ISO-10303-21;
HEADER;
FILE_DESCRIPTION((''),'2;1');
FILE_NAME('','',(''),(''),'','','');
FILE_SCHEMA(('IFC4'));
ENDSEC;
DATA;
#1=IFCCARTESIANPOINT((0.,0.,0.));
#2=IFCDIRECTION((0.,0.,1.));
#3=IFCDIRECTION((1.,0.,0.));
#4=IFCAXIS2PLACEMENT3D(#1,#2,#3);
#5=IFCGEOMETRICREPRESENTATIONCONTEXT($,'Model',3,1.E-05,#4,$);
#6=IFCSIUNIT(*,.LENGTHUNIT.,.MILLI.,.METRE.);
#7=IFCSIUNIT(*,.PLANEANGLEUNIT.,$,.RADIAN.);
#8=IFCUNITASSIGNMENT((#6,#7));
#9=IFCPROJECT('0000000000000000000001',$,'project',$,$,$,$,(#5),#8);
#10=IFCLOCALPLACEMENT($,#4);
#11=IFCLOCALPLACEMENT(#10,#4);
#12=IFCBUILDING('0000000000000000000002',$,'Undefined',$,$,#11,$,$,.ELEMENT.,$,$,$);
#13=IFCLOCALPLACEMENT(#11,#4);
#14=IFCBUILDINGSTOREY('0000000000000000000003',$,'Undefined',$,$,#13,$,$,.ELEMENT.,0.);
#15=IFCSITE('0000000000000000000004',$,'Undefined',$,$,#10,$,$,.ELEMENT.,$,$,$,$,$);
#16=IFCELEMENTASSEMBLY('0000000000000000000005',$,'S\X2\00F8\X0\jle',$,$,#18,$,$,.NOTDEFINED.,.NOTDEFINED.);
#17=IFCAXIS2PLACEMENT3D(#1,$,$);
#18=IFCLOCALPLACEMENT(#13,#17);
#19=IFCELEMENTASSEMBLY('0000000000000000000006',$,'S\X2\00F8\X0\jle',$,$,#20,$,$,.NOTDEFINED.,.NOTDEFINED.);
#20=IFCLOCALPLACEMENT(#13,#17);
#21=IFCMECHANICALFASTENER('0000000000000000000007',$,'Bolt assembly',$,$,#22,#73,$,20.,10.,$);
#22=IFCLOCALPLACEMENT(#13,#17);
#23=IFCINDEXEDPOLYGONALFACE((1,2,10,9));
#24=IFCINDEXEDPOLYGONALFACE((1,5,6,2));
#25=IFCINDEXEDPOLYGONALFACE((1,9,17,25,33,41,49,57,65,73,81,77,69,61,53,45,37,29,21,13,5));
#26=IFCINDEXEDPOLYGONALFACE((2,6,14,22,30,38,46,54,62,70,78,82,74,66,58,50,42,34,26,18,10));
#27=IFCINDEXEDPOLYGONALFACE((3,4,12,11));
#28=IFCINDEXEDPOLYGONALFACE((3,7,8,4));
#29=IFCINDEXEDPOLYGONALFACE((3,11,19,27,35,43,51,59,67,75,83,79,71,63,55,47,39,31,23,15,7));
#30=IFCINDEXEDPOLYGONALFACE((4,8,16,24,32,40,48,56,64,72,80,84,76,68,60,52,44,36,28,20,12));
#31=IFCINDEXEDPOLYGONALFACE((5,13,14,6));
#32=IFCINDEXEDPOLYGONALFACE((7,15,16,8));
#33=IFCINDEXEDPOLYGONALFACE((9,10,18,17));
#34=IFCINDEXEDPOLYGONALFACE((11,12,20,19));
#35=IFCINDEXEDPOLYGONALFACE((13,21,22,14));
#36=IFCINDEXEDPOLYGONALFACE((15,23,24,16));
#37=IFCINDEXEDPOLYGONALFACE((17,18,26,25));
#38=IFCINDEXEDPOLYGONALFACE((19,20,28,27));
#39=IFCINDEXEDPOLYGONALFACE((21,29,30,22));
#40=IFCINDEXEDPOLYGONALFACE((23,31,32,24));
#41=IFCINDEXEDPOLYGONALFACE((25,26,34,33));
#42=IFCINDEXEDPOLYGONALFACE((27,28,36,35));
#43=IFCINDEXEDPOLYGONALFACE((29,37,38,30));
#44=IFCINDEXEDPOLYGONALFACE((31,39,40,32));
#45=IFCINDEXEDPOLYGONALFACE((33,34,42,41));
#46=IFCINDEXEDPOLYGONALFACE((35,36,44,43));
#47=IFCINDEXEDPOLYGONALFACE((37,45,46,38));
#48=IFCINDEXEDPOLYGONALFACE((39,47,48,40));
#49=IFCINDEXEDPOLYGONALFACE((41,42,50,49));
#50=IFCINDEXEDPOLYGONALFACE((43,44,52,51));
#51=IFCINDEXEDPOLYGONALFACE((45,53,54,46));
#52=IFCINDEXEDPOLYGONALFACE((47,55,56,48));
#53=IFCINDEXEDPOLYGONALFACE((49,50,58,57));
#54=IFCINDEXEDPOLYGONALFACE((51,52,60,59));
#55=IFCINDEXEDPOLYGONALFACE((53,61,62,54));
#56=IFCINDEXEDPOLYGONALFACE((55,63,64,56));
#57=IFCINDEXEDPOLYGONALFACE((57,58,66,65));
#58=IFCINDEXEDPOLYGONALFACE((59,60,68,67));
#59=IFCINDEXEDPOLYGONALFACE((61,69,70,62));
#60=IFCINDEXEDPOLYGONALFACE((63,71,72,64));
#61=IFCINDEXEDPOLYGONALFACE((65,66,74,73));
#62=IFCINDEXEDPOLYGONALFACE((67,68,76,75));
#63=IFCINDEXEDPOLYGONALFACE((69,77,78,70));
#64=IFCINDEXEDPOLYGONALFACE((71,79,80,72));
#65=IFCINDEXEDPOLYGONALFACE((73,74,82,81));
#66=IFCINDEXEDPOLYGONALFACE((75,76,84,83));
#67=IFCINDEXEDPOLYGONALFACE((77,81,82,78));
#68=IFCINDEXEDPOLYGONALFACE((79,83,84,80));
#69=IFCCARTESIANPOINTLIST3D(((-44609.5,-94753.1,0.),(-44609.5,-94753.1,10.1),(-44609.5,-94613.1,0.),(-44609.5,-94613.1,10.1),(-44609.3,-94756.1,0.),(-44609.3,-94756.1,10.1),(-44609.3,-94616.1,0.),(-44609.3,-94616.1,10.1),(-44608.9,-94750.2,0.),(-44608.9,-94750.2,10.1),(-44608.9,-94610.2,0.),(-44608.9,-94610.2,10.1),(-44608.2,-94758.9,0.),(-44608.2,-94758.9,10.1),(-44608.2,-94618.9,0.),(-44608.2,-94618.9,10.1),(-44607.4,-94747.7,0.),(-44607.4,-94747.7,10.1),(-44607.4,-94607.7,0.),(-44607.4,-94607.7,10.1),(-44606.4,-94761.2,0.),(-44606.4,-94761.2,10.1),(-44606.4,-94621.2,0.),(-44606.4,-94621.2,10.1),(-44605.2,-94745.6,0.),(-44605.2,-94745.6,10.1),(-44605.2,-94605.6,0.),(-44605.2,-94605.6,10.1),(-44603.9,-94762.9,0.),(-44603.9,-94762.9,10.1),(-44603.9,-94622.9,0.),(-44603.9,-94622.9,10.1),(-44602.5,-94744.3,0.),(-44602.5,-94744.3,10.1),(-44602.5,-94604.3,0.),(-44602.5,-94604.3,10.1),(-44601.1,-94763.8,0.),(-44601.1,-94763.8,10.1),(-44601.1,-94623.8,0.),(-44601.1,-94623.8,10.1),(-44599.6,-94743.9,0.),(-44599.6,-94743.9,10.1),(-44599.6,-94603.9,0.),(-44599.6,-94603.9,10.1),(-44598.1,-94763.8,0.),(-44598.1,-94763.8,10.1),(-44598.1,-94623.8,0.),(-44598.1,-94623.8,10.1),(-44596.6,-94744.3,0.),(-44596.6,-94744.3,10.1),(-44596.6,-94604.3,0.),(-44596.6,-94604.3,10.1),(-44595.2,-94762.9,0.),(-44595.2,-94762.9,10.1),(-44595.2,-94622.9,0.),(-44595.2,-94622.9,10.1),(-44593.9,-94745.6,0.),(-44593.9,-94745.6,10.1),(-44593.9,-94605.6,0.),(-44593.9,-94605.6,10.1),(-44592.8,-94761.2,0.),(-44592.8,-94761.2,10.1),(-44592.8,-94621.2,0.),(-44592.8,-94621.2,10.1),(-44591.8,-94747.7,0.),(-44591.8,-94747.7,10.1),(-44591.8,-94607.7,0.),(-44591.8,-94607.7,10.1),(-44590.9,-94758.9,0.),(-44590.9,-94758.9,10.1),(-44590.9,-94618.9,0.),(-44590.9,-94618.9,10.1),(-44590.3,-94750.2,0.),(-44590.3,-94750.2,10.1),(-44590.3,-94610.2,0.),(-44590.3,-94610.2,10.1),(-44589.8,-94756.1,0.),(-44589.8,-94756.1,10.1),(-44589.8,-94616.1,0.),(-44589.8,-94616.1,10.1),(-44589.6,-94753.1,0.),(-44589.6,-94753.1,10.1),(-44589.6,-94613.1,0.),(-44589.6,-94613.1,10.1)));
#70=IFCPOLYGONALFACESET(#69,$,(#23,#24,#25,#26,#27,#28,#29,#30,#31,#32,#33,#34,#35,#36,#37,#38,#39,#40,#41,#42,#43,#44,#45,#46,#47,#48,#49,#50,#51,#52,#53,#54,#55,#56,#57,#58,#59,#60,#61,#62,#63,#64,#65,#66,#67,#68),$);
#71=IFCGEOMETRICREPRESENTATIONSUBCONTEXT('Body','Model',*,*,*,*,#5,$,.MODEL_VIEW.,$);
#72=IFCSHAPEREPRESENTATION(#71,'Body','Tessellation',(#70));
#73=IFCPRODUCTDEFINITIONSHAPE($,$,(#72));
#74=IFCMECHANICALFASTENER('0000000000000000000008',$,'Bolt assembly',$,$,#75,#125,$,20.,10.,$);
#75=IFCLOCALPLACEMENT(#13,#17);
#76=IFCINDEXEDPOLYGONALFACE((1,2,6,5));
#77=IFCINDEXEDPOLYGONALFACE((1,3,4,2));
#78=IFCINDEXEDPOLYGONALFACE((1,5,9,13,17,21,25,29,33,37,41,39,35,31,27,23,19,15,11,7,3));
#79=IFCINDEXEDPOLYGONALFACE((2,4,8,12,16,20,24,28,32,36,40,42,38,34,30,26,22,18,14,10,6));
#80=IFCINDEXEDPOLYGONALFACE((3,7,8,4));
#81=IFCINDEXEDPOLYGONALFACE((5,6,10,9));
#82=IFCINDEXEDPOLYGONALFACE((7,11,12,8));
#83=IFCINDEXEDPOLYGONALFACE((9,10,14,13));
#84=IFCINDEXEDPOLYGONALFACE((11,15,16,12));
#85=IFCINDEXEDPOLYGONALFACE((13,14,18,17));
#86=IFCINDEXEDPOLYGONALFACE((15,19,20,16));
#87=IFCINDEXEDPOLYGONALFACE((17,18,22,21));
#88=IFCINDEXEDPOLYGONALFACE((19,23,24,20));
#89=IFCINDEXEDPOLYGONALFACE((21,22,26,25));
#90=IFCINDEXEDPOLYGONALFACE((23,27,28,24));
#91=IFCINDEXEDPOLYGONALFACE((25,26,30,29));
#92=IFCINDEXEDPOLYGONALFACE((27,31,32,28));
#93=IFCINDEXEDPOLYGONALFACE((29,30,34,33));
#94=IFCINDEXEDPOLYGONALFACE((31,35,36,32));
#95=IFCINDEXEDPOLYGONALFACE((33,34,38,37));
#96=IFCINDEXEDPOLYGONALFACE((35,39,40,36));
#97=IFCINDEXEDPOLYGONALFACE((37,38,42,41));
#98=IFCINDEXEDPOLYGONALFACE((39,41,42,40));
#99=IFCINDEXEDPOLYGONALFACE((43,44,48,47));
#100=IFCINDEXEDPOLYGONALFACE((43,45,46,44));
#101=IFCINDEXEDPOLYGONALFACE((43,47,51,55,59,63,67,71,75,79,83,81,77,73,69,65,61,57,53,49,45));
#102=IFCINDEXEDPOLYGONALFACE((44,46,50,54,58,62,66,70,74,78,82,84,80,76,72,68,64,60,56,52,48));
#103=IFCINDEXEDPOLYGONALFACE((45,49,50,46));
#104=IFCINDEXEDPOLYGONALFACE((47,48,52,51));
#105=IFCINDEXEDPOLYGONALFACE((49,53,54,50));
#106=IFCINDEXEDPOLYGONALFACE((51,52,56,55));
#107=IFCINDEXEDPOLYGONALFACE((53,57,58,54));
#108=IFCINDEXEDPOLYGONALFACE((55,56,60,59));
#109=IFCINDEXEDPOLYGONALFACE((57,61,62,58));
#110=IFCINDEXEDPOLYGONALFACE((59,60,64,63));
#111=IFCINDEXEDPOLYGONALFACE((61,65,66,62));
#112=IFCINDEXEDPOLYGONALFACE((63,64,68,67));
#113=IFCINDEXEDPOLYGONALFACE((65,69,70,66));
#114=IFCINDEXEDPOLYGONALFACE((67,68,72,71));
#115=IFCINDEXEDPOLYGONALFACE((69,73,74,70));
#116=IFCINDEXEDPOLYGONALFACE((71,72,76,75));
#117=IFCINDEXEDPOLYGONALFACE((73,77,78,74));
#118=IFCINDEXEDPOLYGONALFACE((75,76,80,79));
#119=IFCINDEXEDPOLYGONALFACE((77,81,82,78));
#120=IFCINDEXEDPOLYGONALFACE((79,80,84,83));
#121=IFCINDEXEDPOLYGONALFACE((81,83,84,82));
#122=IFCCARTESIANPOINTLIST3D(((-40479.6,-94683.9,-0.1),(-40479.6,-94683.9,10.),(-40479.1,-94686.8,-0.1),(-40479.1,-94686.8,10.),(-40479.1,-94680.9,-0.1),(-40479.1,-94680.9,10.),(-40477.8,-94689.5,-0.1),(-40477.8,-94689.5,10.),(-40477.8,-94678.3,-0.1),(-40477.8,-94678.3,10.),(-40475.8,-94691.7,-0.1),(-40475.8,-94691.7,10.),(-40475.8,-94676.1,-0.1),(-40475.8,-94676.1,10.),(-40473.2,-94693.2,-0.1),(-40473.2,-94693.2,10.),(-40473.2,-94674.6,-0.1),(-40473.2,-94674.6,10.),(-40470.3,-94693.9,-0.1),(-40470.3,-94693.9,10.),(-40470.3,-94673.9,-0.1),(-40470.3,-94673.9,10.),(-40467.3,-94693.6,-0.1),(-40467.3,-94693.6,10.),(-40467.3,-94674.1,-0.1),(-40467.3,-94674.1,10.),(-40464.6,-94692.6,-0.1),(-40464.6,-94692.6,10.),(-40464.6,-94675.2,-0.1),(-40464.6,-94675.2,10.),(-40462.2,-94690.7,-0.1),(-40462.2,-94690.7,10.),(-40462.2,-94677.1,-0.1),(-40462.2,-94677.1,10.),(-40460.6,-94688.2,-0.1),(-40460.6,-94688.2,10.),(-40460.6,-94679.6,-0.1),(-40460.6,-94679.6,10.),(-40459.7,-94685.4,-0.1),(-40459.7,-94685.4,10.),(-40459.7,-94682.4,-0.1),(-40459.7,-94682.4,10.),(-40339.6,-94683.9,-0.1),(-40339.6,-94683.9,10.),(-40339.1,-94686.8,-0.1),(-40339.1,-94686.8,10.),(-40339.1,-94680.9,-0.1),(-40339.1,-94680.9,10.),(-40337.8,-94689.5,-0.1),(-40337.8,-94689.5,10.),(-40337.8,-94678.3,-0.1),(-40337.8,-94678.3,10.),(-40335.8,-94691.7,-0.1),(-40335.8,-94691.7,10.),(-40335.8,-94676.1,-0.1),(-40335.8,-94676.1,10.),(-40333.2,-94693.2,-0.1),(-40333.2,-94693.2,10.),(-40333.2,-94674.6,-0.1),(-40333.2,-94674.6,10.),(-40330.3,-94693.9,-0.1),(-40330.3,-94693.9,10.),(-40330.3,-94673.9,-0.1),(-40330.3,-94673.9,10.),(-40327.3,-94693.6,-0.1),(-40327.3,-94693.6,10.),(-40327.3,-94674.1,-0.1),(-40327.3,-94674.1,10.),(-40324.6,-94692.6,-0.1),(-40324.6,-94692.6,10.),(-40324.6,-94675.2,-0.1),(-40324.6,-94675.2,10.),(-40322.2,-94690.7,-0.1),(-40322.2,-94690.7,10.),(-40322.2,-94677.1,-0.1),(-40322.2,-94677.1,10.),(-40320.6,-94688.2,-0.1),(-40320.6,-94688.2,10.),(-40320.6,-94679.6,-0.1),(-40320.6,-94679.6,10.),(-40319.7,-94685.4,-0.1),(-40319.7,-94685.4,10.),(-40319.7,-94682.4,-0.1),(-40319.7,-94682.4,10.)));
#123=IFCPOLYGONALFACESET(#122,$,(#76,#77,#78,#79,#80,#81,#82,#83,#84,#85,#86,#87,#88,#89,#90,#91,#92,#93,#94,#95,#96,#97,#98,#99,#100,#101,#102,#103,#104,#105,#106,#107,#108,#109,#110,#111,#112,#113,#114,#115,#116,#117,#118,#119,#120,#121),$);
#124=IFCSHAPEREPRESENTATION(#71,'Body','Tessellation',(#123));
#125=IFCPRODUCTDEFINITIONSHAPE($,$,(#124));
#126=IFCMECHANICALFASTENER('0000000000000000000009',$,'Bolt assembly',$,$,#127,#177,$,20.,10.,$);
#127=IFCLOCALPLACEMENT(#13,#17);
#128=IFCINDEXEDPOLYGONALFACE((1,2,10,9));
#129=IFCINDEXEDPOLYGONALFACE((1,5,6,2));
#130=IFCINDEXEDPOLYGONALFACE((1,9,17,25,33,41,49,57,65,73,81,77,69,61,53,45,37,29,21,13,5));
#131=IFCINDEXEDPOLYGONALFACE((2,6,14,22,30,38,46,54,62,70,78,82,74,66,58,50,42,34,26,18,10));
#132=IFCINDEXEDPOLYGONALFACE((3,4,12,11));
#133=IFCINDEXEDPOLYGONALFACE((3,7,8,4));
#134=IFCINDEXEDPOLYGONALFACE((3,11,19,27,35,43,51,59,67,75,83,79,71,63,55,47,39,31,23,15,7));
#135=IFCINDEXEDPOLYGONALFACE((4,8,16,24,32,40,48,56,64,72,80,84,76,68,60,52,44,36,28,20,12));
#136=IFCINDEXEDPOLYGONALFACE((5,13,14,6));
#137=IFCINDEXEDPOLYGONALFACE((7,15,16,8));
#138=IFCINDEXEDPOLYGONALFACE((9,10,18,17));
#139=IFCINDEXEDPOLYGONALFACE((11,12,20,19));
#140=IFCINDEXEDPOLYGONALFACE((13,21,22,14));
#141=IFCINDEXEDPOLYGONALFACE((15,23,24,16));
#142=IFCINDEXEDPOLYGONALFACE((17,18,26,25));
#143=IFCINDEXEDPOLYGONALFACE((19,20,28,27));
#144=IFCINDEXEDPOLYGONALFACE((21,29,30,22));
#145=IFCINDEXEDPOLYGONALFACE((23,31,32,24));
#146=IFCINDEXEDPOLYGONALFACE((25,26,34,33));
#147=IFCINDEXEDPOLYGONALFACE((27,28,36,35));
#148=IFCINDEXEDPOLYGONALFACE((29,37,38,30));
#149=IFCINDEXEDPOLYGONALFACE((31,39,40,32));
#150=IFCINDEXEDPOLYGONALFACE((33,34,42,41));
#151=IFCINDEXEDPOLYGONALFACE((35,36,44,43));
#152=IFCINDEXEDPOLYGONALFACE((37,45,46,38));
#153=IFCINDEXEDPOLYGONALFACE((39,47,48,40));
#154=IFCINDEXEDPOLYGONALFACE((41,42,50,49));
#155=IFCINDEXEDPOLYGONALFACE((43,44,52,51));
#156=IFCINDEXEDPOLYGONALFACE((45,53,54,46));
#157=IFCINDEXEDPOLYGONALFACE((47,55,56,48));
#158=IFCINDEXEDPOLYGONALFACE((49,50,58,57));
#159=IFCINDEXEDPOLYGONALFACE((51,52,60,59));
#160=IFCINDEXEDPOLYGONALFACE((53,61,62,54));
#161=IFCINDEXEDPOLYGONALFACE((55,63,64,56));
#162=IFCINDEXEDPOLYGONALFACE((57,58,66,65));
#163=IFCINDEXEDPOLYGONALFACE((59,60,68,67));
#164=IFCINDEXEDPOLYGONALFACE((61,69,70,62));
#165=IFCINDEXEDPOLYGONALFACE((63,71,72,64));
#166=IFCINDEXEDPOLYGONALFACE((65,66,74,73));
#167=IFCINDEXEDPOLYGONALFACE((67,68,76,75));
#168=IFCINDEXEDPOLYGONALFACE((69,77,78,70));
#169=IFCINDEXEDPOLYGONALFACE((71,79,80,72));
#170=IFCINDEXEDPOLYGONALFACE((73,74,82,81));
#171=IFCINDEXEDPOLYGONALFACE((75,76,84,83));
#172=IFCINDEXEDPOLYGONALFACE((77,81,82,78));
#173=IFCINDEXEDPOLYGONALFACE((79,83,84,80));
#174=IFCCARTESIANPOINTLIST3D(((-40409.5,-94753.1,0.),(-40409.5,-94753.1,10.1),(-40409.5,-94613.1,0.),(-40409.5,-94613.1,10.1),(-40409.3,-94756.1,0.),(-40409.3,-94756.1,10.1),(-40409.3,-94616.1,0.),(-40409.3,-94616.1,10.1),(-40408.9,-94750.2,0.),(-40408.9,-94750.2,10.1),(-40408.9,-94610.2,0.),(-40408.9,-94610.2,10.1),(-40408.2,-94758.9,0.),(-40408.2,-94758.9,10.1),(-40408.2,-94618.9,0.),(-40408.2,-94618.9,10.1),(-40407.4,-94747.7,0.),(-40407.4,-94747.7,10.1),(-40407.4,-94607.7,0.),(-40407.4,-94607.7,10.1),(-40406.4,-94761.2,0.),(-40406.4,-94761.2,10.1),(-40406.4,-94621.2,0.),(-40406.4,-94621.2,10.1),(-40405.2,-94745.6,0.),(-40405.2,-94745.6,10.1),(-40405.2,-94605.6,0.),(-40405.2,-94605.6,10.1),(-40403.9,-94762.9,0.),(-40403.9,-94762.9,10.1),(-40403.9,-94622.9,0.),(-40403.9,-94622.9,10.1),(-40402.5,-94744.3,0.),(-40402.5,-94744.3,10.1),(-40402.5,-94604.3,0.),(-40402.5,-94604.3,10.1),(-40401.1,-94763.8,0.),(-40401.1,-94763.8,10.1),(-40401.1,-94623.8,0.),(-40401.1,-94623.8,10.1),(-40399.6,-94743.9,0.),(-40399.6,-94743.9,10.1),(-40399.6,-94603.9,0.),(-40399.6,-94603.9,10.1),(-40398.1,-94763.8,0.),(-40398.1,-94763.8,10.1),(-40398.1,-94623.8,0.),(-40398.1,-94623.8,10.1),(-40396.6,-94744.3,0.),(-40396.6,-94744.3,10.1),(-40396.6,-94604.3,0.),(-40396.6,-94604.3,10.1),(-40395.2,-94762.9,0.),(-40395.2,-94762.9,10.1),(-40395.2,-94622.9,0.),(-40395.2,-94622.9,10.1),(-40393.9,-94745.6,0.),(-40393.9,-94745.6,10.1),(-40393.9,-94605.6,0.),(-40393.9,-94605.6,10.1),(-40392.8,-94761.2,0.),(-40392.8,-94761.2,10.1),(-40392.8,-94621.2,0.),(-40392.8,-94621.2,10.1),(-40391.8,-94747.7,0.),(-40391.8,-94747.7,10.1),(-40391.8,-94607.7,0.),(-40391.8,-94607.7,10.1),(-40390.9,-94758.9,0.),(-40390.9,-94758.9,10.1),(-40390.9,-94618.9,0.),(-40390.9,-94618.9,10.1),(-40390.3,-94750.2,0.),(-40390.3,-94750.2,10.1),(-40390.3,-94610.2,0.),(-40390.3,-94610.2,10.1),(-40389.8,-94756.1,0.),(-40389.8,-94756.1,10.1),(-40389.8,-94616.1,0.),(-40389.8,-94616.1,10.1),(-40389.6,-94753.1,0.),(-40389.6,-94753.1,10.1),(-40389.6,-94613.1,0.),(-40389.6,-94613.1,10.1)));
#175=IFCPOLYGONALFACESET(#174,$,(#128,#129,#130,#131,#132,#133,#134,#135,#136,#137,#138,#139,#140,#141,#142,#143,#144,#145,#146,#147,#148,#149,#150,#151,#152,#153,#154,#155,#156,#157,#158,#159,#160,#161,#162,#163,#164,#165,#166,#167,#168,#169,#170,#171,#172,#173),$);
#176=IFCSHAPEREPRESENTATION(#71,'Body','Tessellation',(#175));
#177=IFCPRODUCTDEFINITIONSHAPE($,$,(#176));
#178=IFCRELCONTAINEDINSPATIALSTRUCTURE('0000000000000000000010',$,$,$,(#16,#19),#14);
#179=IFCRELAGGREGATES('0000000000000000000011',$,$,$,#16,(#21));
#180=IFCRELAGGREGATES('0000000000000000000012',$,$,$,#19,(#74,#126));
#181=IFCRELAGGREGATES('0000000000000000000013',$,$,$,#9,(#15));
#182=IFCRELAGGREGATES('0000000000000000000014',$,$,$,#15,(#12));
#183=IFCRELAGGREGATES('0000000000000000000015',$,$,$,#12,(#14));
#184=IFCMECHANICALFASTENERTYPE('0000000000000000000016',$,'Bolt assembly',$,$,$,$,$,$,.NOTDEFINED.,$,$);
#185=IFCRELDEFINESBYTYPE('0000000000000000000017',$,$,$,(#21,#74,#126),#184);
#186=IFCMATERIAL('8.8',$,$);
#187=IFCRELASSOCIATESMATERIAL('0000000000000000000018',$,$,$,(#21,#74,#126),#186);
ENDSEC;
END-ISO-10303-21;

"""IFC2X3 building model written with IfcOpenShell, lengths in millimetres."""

from ifc_helpers import new_model, si_unit, frame, origin_with_axes, origin_2d_with_axis, place, context, subcontext, project, spatial, circle, extrude, source, transform, mapped, material, type_object, element, aggregate, save


model = new_model("IFC2X3")

# Units and contexts
model_context = context("Model", 3, precision=1e-05, world=origin_with_axes())
body_context = subcontext(model_context, "Body", "Model", "MODEL_VIEW")
ifc_project = project(units=[si_unit("LENGTHUNIT", "METRE", prefix="MILLI"), si_unit("PLANEANGLEUNIT", "RADIAN")], contexts=[model_context])

# Site, building, storey
site_placement = place(None, origin_with_axes())
site = spatial("IfcSite", under=ifc_project, at=site_placement, Name="Undefined", CompositionType="ELEMENT")
building_placement = place(site_placement, origin_with_axes())
building = spatial("IfcBuilding", under=site, at=building_placement, Name="Undefined", CompositionType="ELEMENT")
storey_placement = place(building_placement, origin_with_axes())
storey = spatial("IfcBuildingStorey", under=building, at=storey_placement, Name="Undefined", CompositionType="ELEMENT", Elevation=0.0)

# Element assemblies
assembly_1_placement = place(storey_placement, origin_with_axes())
assembly_1 = element("IfcElementAssembly", 1, at=assembly_1_placement, inside=storey, Name="Søjle", AssemblyPlace="NOTDEFINED", PredefinedType="NOTDEFINED")
assembly_2_placement = place(storey_placement, origin_with_axes())
assembly_2 = element("IfcElementAssembly", 2, at=assembly_2_placement, inside=storey, Name="Søjle", AssemblyPlace="NOTDEFINED", PredefinedType="NOTDEFINED")

# Mechanical fasteners
ifc_material_1 = material(Name="8.8")
mechanical_fastener_type = type_object("IfcMechanicalFastenerType", Name="Bolt assembly")
shared_shape_1 = source(origin_with_axes(), body_context, "Body", "SweptSolid", [
    extrude(circle(Radius=10.0, at=origin_2d_with_axis()), frame((0.0, -10.0, 0.0), z_axis=(0.0, 1.0, 0.0), x_axis=(1.0, 0.0, 0.0)), (0.0, 0.0, 1.0), 10.1),
])
mechanical_fastener_1_placement = place(assembly_1_placement, frame((-44599.6, -94753.9, 10.0), z_axis=(1.0, 0.0, 0.0), x_axis=(0.0, 1.0, 0.0)))
mechanical_fastener_1 = element("IfcMechanicalFastener", 3, at=mechanical_fastener_1_placement, type_object=mechanical_fastener_type, material=ifc_material_1, Name="Bolt assembly", NominalDiameter=20.0, NominalLength=10.0, context=body_context, shape_type="MappedRepresentation", body=[
    mapped(shared_shape_1, transform((0.0, 0.0, 0.0))),
    mapped(shared_shape_1, transform((140.0, 0.0, 0.0))),
])
mechanical_fastener_2_placement = place(assembly_2_placement, frame((-40329.6, -94683.9, 0.0), z_axis=(0.0, -1.0, 0.0), x_axis=(-1.0, 0.0, 0.0)))
mechanical_fastener_2 = element("IfcMechanicalFastener", 4, at=mechanical_fastener_2_placement, type_object=mechanical_fastener_type, material=ifc_material_1, Name="Bolt assembly", NominalDiameter=20.0, NominalLength=10.0, context=body_context, shape_type="MappedRepresentation", body=[
    mapped(shared_shape_1, transform((0.0, 0.0, 0.0))),
    mapped(shared_shape_1, transform((140.0, 0.0, 0.0))),
])
mechanical_fastener_3_placement = place(assembly_2_placement, frame((-40399.6, -94753.9, 10.0), z_axis=(1.0, 0.0, 0.0), x_axis=(0.0, 1.0, 0.0)))
mechanical_fastener_3 = element("IfcMechanicalFastener", 5, at=mechanical_fastener_3_placement, type_object=mechanical_fastener_type, material=ifc_material_1, Name="Bolt assembly", NominalDiameter=20.0, NominalLength=10.0, context=body_context, shape_type="MappedRepresentation", body=[
    mapped(shared_shape_1, transform((0.0, 0.0, 0.0))),
    mapped(shared_shape_1, transform((140.0, 0.0, 0.0))),
])
aggregate(assembly_1, [mechanical_fastener_1])
aggregate(assembly_2, [mechanical_fastener_2, mechanical_fastener_3])

save(model, "model.ifc")
